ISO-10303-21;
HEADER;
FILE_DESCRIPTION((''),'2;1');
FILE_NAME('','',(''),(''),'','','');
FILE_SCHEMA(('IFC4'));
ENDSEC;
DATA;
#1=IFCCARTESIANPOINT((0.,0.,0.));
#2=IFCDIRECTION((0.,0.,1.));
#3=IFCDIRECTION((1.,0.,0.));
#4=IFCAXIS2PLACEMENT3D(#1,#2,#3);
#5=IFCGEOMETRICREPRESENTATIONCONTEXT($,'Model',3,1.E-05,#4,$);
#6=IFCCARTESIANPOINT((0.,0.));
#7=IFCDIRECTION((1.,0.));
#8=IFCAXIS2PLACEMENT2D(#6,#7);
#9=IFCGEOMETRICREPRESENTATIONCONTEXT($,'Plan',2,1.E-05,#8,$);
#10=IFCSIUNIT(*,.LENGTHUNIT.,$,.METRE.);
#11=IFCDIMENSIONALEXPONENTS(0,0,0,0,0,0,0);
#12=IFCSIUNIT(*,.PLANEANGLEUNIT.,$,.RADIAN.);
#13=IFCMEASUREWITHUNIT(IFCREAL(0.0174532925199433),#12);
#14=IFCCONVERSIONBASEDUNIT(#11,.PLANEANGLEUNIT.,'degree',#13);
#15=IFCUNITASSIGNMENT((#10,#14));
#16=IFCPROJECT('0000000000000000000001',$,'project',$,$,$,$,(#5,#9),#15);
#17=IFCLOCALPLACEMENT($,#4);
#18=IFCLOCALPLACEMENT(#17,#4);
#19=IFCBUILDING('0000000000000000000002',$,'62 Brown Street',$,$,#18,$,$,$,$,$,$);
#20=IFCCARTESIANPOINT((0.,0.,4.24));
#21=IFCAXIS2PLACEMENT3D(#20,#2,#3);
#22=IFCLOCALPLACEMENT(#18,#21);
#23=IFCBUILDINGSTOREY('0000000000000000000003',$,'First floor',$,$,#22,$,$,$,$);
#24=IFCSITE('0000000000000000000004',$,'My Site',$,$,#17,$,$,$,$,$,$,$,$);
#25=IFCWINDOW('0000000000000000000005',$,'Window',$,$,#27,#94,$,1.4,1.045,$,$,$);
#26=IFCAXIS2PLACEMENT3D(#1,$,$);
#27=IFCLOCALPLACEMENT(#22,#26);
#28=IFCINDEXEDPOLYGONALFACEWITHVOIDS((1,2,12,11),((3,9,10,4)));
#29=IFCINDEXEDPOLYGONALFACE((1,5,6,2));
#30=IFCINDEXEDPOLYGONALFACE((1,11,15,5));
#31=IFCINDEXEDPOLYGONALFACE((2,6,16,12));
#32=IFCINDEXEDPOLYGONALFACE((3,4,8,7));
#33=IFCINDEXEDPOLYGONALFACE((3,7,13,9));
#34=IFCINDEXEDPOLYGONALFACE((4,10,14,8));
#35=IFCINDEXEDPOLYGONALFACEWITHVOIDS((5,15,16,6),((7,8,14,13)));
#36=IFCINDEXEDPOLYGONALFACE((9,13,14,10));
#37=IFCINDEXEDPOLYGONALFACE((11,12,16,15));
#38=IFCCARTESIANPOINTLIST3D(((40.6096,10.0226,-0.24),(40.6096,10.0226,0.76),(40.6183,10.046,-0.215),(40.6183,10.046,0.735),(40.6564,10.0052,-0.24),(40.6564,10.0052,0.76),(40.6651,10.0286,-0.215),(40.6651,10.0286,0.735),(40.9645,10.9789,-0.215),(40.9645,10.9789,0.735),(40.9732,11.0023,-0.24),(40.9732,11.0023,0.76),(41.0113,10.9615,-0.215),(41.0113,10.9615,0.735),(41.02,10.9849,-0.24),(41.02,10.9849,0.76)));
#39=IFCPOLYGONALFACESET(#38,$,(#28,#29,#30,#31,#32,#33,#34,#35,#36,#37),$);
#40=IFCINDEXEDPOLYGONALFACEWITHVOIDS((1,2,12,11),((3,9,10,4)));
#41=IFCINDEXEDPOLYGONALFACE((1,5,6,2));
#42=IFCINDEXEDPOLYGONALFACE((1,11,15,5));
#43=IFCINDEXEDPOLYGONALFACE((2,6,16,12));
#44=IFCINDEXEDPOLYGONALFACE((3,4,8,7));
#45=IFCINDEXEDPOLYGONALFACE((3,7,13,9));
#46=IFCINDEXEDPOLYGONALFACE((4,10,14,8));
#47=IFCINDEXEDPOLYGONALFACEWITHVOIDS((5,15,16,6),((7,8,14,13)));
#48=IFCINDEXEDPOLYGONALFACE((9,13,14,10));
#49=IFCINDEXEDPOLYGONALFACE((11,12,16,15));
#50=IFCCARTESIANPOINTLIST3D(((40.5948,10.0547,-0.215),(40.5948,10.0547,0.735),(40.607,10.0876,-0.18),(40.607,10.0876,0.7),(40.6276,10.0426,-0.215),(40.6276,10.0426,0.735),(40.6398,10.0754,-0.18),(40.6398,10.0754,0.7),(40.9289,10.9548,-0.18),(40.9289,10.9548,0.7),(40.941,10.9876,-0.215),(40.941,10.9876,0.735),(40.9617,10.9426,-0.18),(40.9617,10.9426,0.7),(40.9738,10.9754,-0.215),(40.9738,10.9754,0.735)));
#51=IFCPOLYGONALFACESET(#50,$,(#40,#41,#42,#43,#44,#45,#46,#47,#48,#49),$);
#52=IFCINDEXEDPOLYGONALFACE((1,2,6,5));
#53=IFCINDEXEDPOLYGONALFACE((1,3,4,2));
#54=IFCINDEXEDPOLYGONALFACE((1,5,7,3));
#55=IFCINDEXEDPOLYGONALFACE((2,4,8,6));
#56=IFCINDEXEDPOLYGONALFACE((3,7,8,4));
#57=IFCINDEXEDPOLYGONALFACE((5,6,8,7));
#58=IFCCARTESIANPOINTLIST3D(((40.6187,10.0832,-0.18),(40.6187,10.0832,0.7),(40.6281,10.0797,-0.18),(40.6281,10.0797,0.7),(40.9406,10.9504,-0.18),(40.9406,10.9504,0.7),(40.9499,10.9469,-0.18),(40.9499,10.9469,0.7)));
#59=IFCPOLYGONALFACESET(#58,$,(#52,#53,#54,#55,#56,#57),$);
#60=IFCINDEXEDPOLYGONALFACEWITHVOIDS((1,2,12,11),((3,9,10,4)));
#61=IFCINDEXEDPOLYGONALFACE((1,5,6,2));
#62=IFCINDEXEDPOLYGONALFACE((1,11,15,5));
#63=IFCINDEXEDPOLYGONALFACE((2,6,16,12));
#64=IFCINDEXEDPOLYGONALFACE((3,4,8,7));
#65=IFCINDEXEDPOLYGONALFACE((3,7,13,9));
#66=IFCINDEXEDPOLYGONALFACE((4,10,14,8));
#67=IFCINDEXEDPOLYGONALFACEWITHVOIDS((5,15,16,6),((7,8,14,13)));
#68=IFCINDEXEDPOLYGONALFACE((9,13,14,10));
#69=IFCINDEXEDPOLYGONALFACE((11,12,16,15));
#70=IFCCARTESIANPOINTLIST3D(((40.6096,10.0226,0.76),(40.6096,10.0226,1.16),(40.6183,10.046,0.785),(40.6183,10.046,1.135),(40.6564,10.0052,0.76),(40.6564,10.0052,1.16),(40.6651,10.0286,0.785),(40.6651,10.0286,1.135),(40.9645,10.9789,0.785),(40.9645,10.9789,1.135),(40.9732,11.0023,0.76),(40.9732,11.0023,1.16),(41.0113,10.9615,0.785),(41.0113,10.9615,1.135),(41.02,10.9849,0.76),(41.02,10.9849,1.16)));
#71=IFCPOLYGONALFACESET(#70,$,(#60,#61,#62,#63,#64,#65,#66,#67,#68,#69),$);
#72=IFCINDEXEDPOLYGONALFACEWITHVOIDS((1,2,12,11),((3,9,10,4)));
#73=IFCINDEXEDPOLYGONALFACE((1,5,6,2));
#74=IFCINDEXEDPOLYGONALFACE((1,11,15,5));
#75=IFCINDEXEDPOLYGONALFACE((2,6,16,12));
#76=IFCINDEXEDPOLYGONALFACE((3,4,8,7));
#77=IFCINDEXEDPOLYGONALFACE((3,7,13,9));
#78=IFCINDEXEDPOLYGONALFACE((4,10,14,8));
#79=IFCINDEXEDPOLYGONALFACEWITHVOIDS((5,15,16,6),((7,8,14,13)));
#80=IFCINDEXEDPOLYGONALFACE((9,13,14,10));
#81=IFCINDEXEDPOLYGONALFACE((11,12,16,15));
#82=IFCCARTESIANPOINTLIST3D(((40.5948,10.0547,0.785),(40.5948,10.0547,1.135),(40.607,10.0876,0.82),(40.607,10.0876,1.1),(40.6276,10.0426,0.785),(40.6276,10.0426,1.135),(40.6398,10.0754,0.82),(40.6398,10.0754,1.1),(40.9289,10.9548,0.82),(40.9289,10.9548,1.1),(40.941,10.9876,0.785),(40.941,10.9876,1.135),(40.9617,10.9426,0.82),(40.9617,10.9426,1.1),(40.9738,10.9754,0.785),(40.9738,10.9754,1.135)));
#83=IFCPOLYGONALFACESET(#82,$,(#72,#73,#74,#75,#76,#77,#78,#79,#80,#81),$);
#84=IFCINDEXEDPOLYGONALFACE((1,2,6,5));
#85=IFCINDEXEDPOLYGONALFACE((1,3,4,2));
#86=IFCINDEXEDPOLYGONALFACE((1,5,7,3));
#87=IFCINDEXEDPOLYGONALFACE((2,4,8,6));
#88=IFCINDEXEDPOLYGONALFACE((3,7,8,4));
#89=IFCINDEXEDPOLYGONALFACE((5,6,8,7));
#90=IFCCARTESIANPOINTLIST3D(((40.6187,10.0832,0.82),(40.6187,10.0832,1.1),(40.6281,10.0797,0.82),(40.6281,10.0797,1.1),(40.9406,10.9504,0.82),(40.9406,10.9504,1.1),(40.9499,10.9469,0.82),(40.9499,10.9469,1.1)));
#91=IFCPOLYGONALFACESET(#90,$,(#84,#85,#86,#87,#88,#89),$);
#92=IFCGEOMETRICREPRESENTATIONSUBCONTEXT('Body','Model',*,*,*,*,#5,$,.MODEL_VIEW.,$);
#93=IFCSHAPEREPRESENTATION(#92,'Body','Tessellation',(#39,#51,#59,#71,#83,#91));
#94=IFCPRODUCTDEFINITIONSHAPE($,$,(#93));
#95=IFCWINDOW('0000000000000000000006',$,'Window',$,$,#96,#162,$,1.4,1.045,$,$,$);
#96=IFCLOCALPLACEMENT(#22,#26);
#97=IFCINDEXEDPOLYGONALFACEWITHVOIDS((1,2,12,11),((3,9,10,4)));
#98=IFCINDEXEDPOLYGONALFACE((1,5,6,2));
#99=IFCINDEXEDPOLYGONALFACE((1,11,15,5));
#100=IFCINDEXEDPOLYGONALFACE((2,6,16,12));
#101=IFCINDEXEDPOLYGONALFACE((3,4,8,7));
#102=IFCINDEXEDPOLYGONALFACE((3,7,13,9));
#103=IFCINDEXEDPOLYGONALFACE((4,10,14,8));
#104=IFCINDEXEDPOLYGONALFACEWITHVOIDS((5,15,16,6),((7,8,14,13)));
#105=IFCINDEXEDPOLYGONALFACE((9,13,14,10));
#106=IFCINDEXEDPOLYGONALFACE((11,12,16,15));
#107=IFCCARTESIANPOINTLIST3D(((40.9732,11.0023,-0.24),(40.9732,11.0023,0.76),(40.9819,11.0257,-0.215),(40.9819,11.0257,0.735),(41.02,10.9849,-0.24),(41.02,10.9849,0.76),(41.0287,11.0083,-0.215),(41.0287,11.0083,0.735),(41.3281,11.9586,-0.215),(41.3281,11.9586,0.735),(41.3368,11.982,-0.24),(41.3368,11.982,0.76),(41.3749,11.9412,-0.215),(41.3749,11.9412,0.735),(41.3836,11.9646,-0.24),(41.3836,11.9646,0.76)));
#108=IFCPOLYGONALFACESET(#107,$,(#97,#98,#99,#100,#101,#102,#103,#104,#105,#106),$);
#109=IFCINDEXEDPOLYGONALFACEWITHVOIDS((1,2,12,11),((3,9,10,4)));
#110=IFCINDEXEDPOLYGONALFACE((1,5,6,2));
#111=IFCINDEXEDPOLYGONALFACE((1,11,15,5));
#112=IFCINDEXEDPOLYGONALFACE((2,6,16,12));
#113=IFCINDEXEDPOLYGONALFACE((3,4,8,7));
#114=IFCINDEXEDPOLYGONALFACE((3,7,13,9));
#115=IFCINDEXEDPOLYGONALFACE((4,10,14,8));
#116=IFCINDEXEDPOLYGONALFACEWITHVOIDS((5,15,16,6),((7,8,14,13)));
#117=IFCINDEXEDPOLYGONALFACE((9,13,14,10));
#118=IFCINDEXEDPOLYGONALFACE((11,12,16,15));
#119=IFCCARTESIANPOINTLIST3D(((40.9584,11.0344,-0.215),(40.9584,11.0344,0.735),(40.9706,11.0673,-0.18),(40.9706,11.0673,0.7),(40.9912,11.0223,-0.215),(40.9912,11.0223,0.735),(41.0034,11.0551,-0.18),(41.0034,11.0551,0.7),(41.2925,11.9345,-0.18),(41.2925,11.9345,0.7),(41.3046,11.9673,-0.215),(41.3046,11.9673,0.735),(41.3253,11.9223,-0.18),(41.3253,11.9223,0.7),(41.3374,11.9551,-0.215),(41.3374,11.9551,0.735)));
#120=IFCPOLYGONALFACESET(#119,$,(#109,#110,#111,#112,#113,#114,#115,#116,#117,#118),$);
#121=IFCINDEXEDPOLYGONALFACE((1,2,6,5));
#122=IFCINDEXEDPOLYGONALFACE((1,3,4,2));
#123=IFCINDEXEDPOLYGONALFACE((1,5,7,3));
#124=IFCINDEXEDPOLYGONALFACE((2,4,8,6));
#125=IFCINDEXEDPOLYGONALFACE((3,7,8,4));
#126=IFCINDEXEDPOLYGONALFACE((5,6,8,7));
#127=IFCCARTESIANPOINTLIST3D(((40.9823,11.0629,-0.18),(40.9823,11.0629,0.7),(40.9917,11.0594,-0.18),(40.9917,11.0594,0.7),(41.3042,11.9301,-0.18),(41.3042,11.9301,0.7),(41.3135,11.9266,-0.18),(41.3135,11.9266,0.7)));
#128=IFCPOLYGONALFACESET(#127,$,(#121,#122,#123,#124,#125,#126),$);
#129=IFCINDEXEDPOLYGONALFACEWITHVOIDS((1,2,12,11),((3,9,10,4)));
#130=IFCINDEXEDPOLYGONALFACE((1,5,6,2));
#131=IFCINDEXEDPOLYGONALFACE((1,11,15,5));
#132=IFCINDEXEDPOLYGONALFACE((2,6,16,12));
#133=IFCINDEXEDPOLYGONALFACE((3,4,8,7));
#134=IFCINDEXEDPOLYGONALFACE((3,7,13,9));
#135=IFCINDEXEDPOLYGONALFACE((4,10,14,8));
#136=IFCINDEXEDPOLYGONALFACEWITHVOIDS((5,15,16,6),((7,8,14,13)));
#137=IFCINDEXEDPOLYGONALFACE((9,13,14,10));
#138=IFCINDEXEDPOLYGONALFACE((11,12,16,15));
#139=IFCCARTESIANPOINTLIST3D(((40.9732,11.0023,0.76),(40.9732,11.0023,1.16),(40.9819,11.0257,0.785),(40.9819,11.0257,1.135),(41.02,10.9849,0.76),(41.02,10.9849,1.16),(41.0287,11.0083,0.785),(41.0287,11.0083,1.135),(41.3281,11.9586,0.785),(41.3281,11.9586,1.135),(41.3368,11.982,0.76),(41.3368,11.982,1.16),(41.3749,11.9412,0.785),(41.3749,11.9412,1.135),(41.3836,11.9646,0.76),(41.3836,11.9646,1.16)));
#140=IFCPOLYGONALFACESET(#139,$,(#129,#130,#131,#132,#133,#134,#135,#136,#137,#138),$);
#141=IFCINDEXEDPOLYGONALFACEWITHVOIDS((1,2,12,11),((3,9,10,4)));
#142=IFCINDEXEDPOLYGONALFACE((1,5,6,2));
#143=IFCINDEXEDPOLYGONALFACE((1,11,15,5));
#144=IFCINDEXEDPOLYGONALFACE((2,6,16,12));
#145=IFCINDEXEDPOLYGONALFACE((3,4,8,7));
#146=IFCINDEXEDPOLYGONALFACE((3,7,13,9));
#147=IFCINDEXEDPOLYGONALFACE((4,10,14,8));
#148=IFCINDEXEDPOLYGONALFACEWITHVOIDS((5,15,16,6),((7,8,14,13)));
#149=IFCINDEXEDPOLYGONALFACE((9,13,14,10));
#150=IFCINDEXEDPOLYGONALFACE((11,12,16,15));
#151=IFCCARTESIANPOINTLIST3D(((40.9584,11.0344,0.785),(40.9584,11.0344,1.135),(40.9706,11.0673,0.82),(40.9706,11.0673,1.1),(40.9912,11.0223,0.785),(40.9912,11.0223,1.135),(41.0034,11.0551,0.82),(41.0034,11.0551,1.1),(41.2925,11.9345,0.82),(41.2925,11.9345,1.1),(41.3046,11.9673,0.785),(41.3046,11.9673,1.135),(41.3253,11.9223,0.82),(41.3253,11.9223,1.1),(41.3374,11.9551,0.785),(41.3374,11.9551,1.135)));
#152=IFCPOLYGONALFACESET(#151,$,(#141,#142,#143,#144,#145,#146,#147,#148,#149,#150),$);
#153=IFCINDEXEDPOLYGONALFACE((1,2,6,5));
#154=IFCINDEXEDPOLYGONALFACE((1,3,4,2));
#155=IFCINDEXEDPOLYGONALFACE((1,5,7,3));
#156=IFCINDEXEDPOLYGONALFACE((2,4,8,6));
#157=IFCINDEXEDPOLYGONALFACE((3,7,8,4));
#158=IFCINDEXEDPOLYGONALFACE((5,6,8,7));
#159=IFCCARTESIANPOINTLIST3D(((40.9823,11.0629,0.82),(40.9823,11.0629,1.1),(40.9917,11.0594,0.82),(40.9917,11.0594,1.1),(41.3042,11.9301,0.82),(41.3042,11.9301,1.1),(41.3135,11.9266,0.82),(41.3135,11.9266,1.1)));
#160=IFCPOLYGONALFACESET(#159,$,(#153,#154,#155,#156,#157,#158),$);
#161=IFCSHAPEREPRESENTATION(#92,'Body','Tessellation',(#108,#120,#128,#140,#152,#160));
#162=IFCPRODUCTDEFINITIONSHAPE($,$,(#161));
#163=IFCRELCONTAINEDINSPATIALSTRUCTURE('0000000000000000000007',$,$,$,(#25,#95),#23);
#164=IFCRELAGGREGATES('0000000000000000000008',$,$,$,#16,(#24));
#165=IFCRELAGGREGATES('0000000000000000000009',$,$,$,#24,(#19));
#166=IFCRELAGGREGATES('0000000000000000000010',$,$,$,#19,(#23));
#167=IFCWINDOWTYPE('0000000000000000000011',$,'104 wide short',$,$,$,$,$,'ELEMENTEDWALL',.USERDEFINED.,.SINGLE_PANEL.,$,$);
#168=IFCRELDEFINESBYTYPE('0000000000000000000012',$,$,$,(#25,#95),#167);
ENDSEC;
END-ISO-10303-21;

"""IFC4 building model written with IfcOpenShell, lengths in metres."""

from ifc_helpers import new_model, entity, si_unit, converted_unit, frame, origin_with_axes, origin_2d_with_axis, place, context, subcontext, project, spatial, line, indexed_curve, outline, extrude, shape, source, transform, mapped, type_object, type_shapes, element, save


model = new_model("IFC4")

# Units and contexts
model_context = context("Model", 3, precision=1e-05, world=origin_with_axes())
plan_context = context("Plan", 2, precision=1e-05, world=origin_2d_with_axis())
body_context_1 = subcontext(model_context, "Body", "Model", "MODEL_VIEW")
body_context_2 = subcontext(plan_context, "Body", "Plan", "PLAN_VIEW")
ifc_project = project(units=[si_unit("LENGTHUNIT", "METRE"), converted_unit("PLANEANGLEUNIT", "degree", entity("IfcReal", 0.0174532925199433), si_unit("PLANEANGLEUNIT", "RADIAN"), dimensions=[0, 0, 0, 0, 0, 0, 0])], contexts=[model_context, plan_context])

# Site, building, storey
site_placement = place(None, origin_with_axes())
site = spatial("IfcSite", under=ifc_project, at=site_placement, Name="My Site")
building_placement = place(site_placement, origin_with_axes())
building = spatial("IfcBuilding", under=site, at=building_placement, Name="62 Brown Street")
storey_placement = place(building_placement, frame((0.0, 0.0, 4.24), z_axis=(0.0, 0.0, 1.0), x_axis=(1.0, 0.0, 0.0)))
storey = spatial("IfcBuildingStorey", under=building, at=storey_placement, Name="First floor")

# Shared definitions
window_type = type_object("IfcWindowType", Name="104 wide short", ElementType="ELEMENTEDWALL", PartitioningType="SINGLE_PANEL", PredefinedType="USERDEFINED")
shared_shape_1 = source(origin_with_axes(), body_context_1, "Body", "SweptSolid", [
    extrude(outline(indexed_curve([(0.0, 0.0), (1.045, 0.0), (1.045, 1.0), (0.0, 1.0)], segments=[line(1, 2, 3, 4, 1)]), holes=[indexed_curve([(0.025, 0.025), (1.02, 0.025), (1.02, 0.975), (0.025, 0.975)], segments=[line(1, 2, 3, 4, 1)])]), frame((0.0, 0.15, 0.0), z_axis=(0.0, -1.0, 0.0), x_axis=(1.0, 0.0, 0.0)), (0.0, 0.0, -1.0), 0.05),
    extrude(outline(indexed_curve([(0.0, 0.0), (0.995, 0.0), (0.995, 0.95), (0.0, 0.95)], segments=[line(1, 2, 3, 4, 1)]), holes=[indexed_curve([(0.035, 0.035), (0.96, 0.035), (0.96, 0.915), (0.035, 0.915)], segments=[line(1, 2, 3, 4, 1)])]), frame((0.025, 0.19, 0.025), z_axis=(0.0, -1.0, 0.0), x_axis=(1.0, 0.0, 0.0)), (0.0, 0.0, -1.0), 0.035),
    extrude(outline(indexed_curve([(0.035, 0.035), (0.96, 0.035), (0.96, 0.915), (0.035, 0.915)], segments=[line(1, 2, 3, 4, 1)])), frame((0.025, 0.2025, 0.025), z_axis=(0.0, -1.0, 0.0), x_axis=(1.0, 0.0, 0.0)), (0.0, 0.0, -1.0), 0.01),
    extrude(outline(indexed_curve([(0.0, 0.0), (1.045, 0.0), (1.045, 0.4), (0.0, 0.4)], segments=[line(1, 2, 3, 4, 1)]), holes=[indexed_curve([(0.025, 0.025), (1.02, 0.025), (1.02, 0.375), (0.025, 0.375)], segments=[line(1, 2, 3, 4, 1)])]), frame((0.0, 0.15, 1.0), z_axis=(0.0, -1.0, 0.0), x_axis=(1.0, 0.0, 0.0)), (0.0, 0.0, -1.0), 0.05),
    extrude(outline(indexed_curve([(0.0, 0.0), (0.995, 0.0), (0.995, 0.35), (0.0, 0.35)], segments=[line(1, 2, 3, 4, 1)]), holes=[indexed_curve([(0.035, 0.035), (0.96, 0.035), (0.96, 0.315), (0.035, 0.315)], segments=[line(1, 2, 3, 4, 1)])]), frame((0.025, 0.19, 1.025), z_axis=(0.0, -1.0, 0.0), x_axis=(1.0, 0.0, 0.0)), (0.0, 0.0, -1.0), 0.035),
    extrude(outline(indexed_curve([(0.035, 0.035), (0.96, 0.035), (0.96, 0.315), (0.035, 0.315)], segments=[line(1, 2, 3, 4, 1)])), frame((0.025, 0.2025, 1.025), z_axis=(0.0, -1.0, 0.0), x_axis=(1.0, 0.0, 0.0)), (0.0, 0.0, -1.0), 0.01),
])
shared_shape_2 = source(origin_with_axes(), body_context_2, "Body", "Curve2D", [
    entity("IfcIndexedPolyCurve", entity("IfcCartesianPointList2D", [[0.025, 0.15], [1.02, 0.15]])),
    entity("IfcIndexedPolyCurve", entity("IfcCartesianPointList2D", [[0.0, 0.2], [0.025, 0.2], [0.025, 0.15], [0.0, 0.15]]), [entity("IfcLineIndex", [1, 2, 3, 4, 1])]),
    entity("IfcIndexedPolyCurve", entity("IfcCartesianPointList2D", [[1.045, 0.2], [1.02, 0.2], [1.02, 0.15], [1.045, 0.15]]), [entity("IfcLineIndex", [1, 2, 3, 4, 1])]),
    entity("IfcIndexedPolyCurve", entity("IfcCartesianPointList2D", [[0.025, 0.19], [0.06, 0.19], [0.06, 0.225], [0.025, 0.225]]), [entity("IfcLineIndex", [1, 2, 3, 4, 1])]),
    entity("IfcIndexedPolyCurve", entity("IfcCartesianPointList2D", [[1.02, 0.19], [0.985, 0.19], [0.985, 0.225], [1.02, 0.225]]), [entity("IfcLineIndex", [1, 2, 3, 4, 1])]),
    entity("IfcIndexedPolyCurve", entity("IfcCartesianPointList2D", [[0.06, 0.19], [0.985, 0.19]])),
    entity("IfcIndexedPolyCurve", entity("IfcCartesianPointList2D", [[0.06, 0.225], [0.985, 0.225]])),
    entity("IfcIndexedPolyCurve", entity("IfcCartesianPointList2D", [[0.06, 0.2075], [0.985, 0.2075]])),
])
type_shapes(window_type, [shared_shape_1, shared_shape_2])

# Windows
for number, where, z_axis, x_axis, name in (
    (1, (40.7971, 9.953, -0.24), (0.0, 0.0, 1.0), (0.347944, 0.937515, 0.0), "Window"),
    (2, (41.1607, 10.9327, -0.24), (0.0, 0.0, 1.0), (0.347944, 0.937515, 0.0), "Window"),
):
    element("IfcWindow", number, at=place(storey_placement, frame(where, z_axis=z_axis, x_axis=x_axis)), inside=storey, type_object=window_type, Name=name, OverallHeight=1.4, OverallWidth=1.045, shapes=[
        shape(body_context_1, "Body", "MappedRepresentation", [mapped(shared_shape_1, transform((0.0, 0.0, 0.0), x_axis=(1.0, 0.0, 0.0), y_axis=(0.0, 1.0, 0.0), z_axis=(0.0, 0.0, 1.0), scale=1.0))]),
        shape(body_context_2, "Body", "MappedRepresentation", [mapped(shared_shape_2, transform((0.0, 0.0, 0.0), x_axis=(1.0, 0.0, 0.0), y_axis=(0.0, 1.0, 0.0), z_axis=(0.0, 0.0, 1.0), scale=1.0))]),
    ])

save(model, "model.ifc")
